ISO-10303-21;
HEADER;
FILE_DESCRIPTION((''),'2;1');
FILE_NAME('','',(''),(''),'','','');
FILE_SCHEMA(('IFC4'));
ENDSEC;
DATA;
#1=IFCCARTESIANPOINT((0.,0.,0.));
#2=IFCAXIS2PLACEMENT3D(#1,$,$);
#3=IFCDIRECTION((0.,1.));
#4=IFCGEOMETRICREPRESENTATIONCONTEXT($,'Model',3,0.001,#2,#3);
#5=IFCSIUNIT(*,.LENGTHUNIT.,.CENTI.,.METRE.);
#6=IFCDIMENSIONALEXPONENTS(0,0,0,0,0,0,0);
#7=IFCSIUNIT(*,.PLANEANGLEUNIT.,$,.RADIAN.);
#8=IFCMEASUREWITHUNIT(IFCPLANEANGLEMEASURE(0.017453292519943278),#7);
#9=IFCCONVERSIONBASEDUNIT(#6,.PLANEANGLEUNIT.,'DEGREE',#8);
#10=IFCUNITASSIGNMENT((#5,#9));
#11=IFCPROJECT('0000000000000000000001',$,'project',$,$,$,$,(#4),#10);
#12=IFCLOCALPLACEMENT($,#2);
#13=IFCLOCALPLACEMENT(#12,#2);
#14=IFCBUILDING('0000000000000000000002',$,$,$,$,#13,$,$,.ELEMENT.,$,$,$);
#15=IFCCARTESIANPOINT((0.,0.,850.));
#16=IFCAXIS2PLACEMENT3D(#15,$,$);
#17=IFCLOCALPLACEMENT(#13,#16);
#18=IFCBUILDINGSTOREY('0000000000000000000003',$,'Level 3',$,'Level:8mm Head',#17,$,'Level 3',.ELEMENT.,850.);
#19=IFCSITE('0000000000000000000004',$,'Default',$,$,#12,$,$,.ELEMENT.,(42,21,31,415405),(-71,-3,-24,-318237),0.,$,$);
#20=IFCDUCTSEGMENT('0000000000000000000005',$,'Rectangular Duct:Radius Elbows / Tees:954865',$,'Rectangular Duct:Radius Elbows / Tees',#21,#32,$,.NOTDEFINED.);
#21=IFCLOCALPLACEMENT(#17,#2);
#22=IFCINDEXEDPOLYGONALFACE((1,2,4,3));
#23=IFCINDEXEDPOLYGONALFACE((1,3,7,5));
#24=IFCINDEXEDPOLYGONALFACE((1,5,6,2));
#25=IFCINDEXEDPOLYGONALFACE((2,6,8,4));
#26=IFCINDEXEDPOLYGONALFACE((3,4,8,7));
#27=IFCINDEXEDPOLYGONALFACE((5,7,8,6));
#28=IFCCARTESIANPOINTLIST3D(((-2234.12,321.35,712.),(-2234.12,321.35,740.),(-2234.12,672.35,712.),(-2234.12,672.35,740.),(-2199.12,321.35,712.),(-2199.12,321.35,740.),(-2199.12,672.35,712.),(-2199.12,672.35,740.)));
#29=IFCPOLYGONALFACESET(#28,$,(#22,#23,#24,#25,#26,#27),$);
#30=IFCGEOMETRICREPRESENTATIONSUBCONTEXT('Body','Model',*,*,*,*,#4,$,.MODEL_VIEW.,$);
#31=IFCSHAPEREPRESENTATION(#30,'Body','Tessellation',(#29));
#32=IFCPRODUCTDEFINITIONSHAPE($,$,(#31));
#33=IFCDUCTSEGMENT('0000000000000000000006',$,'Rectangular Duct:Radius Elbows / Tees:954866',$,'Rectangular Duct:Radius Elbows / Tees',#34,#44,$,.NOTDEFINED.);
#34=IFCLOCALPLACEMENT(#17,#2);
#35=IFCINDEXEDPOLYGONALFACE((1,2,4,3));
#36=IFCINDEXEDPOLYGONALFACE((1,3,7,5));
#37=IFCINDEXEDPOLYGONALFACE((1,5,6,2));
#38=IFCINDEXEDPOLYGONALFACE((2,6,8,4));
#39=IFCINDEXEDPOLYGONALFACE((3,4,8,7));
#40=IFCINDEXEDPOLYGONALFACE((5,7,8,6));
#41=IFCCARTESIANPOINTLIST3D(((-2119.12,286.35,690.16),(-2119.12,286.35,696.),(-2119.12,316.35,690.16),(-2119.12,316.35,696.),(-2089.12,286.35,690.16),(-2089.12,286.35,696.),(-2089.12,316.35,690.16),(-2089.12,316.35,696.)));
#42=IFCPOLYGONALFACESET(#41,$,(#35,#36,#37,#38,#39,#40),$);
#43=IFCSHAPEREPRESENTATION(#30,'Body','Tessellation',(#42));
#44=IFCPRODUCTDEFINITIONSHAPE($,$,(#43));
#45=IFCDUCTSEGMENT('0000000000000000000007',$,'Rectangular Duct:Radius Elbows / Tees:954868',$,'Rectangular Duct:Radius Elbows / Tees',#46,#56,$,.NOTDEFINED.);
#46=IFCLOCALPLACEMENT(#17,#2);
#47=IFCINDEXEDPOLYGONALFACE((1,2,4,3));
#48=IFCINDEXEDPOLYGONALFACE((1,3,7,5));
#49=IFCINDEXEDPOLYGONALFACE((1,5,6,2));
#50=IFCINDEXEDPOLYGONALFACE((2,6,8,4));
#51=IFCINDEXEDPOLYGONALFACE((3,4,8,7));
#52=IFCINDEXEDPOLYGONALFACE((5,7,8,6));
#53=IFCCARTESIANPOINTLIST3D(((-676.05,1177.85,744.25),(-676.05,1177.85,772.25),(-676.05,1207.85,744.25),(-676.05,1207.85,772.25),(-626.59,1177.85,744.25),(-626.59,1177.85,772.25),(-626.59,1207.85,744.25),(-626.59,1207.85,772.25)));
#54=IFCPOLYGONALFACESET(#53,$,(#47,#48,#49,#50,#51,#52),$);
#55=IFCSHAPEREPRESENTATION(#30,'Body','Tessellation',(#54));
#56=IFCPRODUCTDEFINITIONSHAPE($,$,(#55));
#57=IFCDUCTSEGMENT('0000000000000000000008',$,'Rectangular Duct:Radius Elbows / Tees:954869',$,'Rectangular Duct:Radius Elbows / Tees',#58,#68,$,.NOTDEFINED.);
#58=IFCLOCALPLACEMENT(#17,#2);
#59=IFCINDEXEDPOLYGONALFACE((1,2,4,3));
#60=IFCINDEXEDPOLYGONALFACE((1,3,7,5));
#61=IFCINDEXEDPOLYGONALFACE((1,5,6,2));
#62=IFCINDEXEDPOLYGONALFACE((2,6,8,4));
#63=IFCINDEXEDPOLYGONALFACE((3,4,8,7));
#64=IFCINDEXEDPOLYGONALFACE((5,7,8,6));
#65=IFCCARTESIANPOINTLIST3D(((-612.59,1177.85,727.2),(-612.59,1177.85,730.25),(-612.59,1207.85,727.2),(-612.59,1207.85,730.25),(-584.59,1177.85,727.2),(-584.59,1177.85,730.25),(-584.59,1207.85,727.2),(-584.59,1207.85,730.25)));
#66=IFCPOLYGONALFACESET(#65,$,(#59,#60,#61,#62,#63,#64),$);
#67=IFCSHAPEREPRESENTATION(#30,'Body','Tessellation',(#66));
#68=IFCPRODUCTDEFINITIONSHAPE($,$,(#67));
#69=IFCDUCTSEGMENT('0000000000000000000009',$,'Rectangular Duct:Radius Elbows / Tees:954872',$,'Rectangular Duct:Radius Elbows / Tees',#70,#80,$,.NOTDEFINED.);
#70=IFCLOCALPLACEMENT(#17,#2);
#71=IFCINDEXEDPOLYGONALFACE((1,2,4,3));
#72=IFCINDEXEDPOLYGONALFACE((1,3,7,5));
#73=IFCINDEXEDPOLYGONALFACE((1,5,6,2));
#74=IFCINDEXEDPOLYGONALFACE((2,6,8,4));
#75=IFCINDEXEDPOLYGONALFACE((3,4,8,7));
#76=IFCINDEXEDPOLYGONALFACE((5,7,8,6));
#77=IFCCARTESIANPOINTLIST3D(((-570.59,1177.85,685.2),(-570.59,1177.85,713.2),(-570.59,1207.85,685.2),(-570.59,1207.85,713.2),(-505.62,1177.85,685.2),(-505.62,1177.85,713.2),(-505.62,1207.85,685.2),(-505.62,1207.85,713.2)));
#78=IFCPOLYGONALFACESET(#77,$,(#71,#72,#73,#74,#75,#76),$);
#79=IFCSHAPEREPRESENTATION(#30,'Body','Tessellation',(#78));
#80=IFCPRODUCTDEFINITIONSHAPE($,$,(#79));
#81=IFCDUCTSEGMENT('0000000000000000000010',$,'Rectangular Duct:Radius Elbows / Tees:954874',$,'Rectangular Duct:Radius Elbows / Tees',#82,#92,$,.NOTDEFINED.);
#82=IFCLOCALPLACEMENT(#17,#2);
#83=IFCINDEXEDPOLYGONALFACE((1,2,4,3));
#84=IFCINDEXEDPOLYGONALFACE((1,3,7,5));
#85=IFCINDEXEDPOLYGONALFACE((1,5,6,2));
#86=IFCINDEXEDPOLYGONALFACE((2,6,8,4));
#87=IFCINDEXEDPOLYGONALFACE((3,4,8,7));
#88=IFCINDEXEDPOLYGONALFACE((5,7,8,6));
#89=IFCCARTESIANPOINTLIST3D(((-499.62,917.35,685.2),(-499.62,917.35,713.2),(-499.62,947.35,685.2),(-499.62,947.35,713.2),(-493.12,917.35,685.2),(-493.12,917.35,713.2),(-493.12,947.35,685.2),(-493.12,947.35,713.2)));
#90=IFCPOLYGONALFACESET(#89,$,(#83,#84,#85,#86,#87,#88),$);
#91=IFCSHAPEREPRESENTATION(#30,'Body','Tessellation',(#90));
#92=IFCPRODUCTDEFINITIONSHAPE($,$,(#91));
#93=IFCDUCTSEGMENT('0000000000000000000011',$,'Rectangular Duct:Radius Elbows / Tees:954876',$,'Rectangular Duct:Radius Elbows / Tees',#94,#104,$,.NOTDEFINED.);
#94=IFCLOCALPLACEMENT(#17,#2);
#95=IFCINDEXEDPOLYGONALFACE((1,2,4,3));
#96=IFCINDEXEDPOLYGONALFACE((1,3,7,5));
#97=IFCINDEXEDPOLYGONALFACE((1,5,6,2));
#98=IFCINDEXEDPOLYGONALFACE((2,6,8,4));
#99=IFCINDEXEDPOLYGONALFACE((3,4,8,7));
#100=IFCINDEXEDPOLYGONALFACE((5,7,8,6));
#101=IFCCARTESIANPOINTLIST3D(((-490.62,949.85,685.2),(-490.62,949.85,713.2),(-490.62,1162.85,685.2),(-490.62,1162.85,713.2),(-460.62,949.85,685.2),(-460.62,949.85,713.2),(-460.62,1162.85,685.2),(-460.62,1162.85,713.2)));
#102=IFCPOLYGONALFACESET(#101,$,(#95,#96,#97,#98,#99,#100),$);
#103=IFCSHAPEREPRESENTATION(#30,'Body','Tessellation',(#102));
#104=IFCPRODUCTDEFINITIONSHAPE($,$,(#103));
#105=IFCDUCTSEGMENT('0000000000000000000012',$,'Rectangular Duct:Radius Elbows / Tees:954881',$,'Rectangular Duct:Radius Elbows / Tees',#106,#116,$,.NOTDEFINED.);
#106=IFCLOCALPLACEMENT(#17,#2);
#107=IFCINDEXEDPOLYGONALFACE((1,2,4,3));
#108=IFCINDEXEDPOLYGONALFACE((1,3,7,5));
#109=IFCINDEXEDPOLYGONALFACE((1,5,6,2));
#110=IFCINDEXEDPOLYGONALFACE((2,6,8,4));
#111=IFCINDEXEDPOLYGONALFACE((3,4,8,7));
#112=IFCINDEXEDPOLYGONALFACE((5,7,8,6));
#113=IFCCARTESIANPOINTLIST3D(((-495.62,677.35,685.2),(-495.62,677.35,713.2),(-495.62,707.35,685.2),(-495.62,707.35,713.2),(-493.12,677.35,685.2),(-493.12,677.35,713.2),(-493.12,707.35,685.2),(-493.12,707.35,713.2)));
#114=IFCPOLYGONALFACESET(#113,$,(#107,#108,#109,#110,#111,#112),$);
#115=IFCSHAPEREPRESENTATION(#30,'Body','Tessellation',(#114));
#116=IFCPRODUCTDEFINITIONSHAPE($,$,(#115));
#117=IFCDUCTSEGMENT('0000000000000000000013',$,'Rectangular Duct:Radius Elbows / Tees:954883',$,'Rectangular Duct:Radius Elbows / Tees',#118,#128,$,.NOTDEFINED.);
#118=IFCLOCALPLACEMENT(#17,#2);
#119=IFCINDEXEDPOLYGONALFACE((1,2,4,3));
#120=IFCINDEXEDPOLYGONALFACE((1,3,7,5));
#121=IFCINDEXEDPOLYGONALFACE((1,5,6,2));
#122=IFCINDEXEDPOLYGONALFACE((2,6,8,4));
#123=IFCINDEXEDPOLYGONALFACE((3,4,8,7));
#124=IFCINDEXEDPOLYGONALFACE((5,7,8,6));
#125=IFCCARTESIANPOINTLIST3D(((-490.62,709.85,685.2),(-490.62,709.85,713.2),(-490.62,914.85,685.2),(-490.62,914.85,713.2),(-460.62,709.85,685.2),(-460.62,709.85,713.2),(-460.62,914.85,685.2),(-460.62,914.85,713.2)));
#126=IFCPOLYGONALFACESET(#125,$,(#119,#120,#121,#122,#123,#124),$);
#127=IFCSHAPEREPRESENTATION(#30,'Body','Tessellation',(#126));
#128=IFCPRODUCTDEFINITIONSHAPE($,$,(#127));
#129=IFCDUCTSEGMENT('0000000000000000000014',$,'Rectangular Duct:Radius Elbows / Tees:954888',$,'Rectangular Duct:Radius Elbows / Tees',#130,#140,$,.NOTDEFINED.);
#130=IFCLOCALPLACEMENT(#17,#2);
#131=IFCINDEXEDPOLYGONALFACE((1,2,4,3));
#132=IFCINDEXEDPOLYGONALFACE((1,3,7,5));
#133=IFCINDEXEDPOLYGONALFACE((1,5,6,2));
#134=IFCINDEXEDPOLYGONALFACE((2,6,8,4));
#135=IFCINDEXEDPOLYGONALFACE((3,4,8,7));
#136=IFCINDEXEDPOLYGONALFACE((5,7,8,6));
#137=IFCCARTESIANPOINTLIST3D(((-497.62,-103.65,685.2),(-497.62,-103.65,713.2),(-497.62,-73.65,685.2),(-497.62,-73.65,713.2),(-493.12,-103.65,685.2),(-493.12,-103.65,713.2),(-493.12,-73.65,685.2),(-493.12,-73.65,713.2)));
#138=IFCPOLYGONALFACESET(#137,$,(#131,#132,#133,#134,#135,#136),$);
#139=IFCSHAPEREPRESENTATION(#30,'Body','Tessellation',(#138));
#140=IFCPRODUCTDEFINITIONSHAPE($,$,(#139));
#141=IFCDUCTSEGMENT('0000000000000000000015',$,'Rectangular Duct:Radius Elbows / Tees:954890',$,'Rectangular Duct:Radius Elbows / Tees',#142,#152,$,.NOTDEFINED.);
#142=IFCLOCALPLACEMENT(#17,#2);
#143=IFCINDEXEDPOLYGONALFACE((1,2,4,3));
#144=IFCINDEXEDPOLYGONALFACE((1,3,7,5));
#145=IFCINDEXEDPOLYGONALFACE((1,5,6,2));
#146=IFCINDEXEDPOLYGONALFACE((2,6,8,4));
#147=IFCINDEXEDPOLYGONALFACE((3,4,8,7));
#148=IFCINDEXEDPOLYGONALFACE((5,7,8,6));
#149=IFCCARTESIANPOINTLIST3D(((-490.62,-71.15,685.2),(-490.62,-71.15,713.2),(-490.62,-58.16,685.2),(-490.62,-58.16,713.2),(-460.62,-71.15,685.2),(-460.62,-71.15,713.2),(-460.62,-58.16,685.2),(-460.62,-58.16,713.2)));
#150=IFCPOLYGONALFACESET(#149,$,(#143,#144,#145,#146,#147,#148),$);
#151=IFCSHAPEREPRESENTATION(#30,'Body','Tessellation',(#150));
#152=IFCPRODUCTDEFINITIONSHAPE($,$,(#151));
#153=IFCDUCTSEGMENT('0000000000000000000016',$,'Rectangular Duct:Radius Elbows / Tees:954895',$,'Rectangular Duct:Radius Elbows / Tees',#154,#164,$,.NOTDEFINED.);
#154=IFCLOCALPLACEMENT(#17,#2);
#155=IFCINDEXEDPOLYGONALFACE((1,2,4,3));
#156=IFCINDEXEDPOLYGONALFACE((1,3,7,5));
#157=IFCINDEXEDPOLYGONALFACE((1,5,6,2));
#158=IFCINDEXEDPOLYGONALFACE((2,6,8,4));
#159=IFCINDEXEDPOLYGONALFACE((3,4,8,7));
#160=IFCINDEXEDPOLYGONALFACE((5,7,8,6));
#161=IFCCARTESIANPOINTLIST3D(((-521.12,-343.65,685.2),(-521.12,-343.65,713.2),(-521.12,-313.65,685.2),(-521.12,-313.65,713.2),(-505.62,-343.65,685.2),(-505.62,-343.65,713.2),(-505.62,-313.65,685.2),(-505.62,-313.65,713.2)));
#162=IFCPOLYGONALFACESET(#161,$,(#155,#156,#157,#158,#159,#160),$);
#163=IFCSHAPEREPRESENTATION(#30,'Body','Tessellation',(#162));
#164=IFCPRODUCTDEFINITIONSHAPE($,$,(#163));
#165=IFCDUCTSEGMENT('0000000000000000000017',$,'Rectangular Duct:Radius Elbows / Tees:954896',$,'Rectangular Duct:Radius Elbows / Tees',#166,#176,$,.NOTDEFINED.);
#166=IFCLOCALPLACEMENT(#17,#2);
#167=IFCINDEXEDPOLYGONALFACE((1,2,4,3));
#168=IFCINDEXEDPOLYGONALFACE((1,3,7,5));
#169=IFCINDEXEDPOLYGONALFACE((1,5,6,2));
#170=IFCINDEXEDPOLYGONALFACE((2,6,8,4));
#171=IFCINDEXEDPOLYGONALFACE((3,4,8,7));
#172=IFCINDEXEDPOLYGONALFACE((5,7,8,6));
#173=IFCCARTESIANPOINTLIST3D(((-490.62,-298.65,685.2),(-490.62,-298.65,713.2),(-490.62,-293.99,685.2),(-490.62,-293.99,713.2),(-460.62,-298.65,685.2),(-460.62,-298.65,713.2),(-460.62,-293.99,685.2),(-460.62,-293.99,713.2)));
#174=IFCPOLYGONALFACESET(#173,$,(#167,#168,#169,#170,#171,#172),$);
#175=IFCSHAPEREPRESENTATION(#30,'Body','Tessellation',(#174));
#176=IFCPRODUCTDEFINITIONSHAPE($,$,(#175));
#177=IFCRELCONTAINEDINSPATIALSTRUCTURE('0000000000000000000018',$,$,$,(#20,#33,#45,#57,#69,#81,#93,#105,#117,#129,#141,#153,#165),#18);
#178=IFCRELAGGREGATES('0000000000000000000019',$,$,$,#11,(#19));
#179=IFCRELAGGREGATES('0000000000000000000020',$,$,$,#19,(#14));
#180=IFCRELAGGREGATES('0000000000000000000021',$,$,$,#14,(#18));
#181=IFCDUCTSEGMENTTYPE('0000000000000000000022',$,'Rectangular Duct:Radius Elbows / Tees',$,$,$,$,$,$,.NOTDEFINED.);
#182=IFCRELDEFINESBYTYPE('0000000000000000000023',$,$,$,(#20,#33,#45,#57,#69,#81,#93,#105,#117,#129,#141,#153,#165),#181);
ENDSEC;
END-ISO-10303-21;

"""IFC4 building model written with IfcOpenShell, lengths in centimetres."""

from ifc_helpers import new_model, entity, si_unit, converted_unit, direction, frame, origin, place, context, subcontext, project, spatial, indexed_curve, outline, extrude, type_object, element, save


model = new_model("IFC4")

# Units and contexts
model_context = context("Model", 3, precision=0.001, world=origin(), true_north=direction((0.0, 1.0)))
body_context = subcontext(model_context, "Body", "Model", "MODEL_VIEW")
ifc_project = project(units=[si_unit("LENGTHUNIT", "METRE", prefix="CENTI"), converted_unit("PLANEANGLEUNIT", "DEGREE", entity("IfcPlaneAngleMeasure", 0.017453292519943278), si_unit("PLANEANGLEUNIT", "RADIAN"), dimensions=[0, 0, 0, 0, 0, 0, 0])], contexts=[model_context])

# Site, building, storey
site_placement = place(None, origin())
site = spatial("IfcSite", under=ifc_project, at=site_placement, Name="Default", CompositionType="ELEMENT", RefLatitude=(42, 21, 31, 415405), RefLongitude=(-71, -3, -24, -318237), RefElevation=0.0)
building_placement = place(site_placement, origin())
building = spatial("IfcBuilding", under=site, at=building_placement, CompositionType="ELEMENT")
storey_placement = place(building_placement, frame((0.0, 0.0, 850.0)))
storey = spatial("IfcBuildingStorey", under=building, at=storey_placement, Name="Level 3", ObjectType="Level:8mm Head", LongName="Level 3", CompositionType="ELEMENT", Elevation=850.0)

# Duct segments
duct_segment_type = type_object("IfcDuctSegmentType", Name="Rectangular Duct:Radius Elbows / Tees", PredefinedType="NOTDEFINED")
duct_segment_1_placement = place(storey_placement, origin())
element("IfcDuctSegment", 1, at=duct_segment_1_placement, inside=storey, type_object=duct_segment_type, Name="Rectangular Duct:Radius Elbows / Tees:954865", ObjectType="Rectangular Duct:Radius Elbows / Tees", PredefinedType="NOTDEFINED", context=body_context, shape_type="SweptSolid", body=[
    extrude(outline(indexed_curve([(-175.5, -17.5), (175.5, -17.5), (175.5, 17.5), (-175.5, 17.5), (-175.5, -17.5)], self_intersect=False)), frame((-2216.62, 496.85, 712.0), z_axis=(0.0, 0.0, 1.0), x_axis=(0.0, -1.0, 0.0)), (0.0, 0.0, 1.0), 28.0),
])
duct_segment_2_placement = place(storey_placement, origin())
element("IfcDuctSegment", 2, at=duct_segment_2_placement, inside=storey, type_object=duct_segment_type, Name="Rectangular Duct:Radius Elbows / Tees:954866", ObjectType="Rectangular Duct:Radius Elbows / Tees", PredefinedType="NOTDEFINED", context=body_context, shape_type="SweptSolid", body=[
    extrude(outline(indexed_curve([(-15.0, -15.0), (15.0, -15.0), (15.0, 15.0), (-15.0, 15.0), (-15.0, -15.0)], self_intersect=False)), frame((-2104.12, 301.35, 690.16)), (0.0, 0.0, 1.0), 5.84),
])
duct_segment_3_placement = place(storey_placement, origin())
element("IfcDuctSegment", 3, at=duct_segment_3_placement, inside=storey, type_object=duct_segment_type, Name="Rectangular Duct:Radius Elbows / Tees:954868", ObjectType="Rectangular Duct:Radius Elbows / Tees", PredefinedType="NOTDEFINED", context=body_context, shape_type="SweptSolid", body=[
    extrude(outline(indexed_curve([(-24.73, -15.0), (24.73, -15.0), (24.73, 15.0), (-24.73, 15.0), (-24.73, -15.0)], self_intersect=False)), frame((-651.32, 1192.85, 744.25)), (0.0, 0.0, 1.0), 28.0),
])
duct_segment_4_placement = place(storey_placement, origin())
element("IfcDuctSegment", 4, at=duct_segment_4_placement, inside=storey, type_object=duct_segment_type, Name="Rectangular Duct:Radius Elbows / Tees:954869", ObjectType="Rectangular Duct:Radius Elbows / Tees", PredefinedType="NOTDEFINED", context=body_context, shape_type="SweptSolid", body=[
    extrude(outline(indexed_curve([(-15.0, -14.0), (15.0, -14.0), (15.0, 14.0), (-15.0, 14.0), (-15.0, -14.0)], self_intersect=False)), frame((-598.59, 1192.85, 727.2), z_axis=(0.0, 0.0, 1.0), x_axis=(0.0, -1.0, 0.0)), (0.0, 0.0, 1.0), 3.05),
])
duct_segment_5_placement = place(storey_placement, origin())
element("IfcDuctSegment", 5, at=duct_segment_5_placement, inside=storey, type_object=duct_segment_type, Name="Rectangular Duct:Radius Elbows / Tees:954872", ObjectType="Rectangular Duct:Radius Elbows / Tees", PredefinedType="NOTDEFINED", context=body_context, shape_type="SweptSolid", body=[
    extrude(outline(indexed_curve([(-32.48, -15.0), (32.48, -15.0), (32.48, 15.0), (-32.48, 15.0), (-32.48, -15.0)], self_intersect=False)), frame((-538.11, 1192.85, 685.2)), (0.0, 0.0, 1.0), 28.0),
])
duct_segment_6_placement = place(storey_placement, origin())
element("IfcDuctSegment", 6, at=duct_segment_6_placement, inside=storey, type_object=duct_segment_type, Name="Rectangular Duct:Radius Elbows / Tees:954874", ObjectType="Rectangular Duct:Radius Elbows / Tees", PredefinedType="NOTDEFINED", context=body_context, shape_type="SweptSolid", body=[
    extrude(outline(indexed_curve([(-3.25, -15.0), (3.25, -15.0), (3.25, 15.0), (-3.25, 15.0), (-3.25, -15.0)], self_intersect=False)), frame((-496.37, 932.35, 685.2), z_axis=(0.0, 0.0, 1.0), x_axis=(-1.0, 0.0, 0.0)), (0.0, 0.0, 1.0), 28.0),
])
duct_segment_7_placement = place(storey_placement, origin())
element("IfcDuctSegment", 7, at=duct_segment_7_placement, inside=storey, type_object=duct_segment_type, Name="Rectangular Duct:Radius Elbows / Tees:954876", ObjectType="Rectangular Duct:Radius Elbows / Tees", PredefinedType="NOTDEFINED", context=body_context, shape_type="SweptSolid", body=[
    extrude(outline(indexed_curve([(-106.5, -15.0), (106.5, -15.0), (106.5, 15.0), (-106.5, 15.0), (-106.5, -15.0)], self_intersect=False)), frame((-475.62, 1056.35, 685.2), z_axis=(0.0, 0.0, 1.0), x_axis=(0.0, -1.0, 0.0)), (0.0, 0.0, 1.0), 28.0),
])
duct_segment_8_placement = place(storey_placement, origin())
element("IfcDuctSegment", 8, at=duct_segment_8_placement, inside=storey, type_object=duct_segment_type, Name="Rectangular Duct:Radius Elbows / Tees:954881", ObjectType="Rectangular Duct:Radius Elbows / Tees", PredefinedType="NOTDEFINED", context=body_context, shape_type="SweptSolid", body=[
    extrude(outline(indexed_curve([(-1.25, -15.0), (1.25, -15.0), (1.25, 15.0), (-1.25, 15.0), (-1.25, -15.0)], self_intersect=False)), frame((-494.37, 692.35, 685.2), z_axis=(0.0, 0.0, 1.0), x_axis=(-1.0, 0.0, 0.0)), (0.0, 0.0, 1.0), 28.0),
])
duct_segment_9_placement = place(storey_placement, origin())
element("IfcDuctSegment", 9, at=duct_segment_9_placement, inside=storey, type_object=duct_segment_type, Name="Rectangular Duct:Radius Elbows / Tees:954883", ObjectType="Rectangular Duct:Radius Elbows / Tees", PredefinedType="NOTDEFINED", context=body_context, shape_type="SweptSolid", body=[
    extrude(outline(indexed_curve([(-102.5, -15.0), (102.5, -15.0), (102.5, 15.0), (-102.5, 15.0), (-102.5, -15.0)], self_intersect=False)), frame((-475.62, 812.35, 685.2), z_axis=(0.0, 0.0, 1.0), x_axis=(0.0, -1.0, 0.0)), (0.0, 0.0, 1.0), 28.0),
])
duct_segment_10_placement = place(storey_placement, origin())
element("IfcDuctSegment", 10, at=duct_segment_10_placement, inside=storey, type_object=duct_segment_type, Name="Rectangular Duct:Radius Elbows / Tees:954888", ObjectType="Rectangular Duct:Radius Elbows / Tees", PredefinedType="NOTDEFINED", context=body_context, shape_type="SweptSolid", body=[
    extrude(outline(indexed_curve([(-2.25, -15.0), (2.25, -15.0), (2.25, 15.0), (-2.25, 15.0), (-2.25, -15.0)], self_intersect=False)), frame((-495.37, -88.65, 685.2), z_axis=(0.0, 0.0, 1.0), x_axis=(-1.0, 0.0, 0.0)), (0.0, 0.0, 1.0), 28.0),
])
duct_segment_11_placement = place(storey_placement, origin())
element("IfcDuctSegment", 11, at=duct_segment_11_placement, inside=storey, type_object=duct_segment_type, Name="Rectangular Duct:Radius Elbows / Tees:954890", ObjectType="Rectangular Duct:Radius Elbows / Tees", PredefinedType="NOTDEFINED", context=body_context, shape_type="SweptSolid", body=[
    extrude(outline(indexed_curve([(-6.5, -15.0), (6.5, -15.0), (6.5, 15.0), (-6.5, 15.0), (-6.5, -15.0)], self_intersect=False)), frame((-475.62, -64.66, 685.2), z_axis=(0.0, 0.0, 1.0), x_axis=(0.0, -1.0, 0.0)), (0.0, 0.0, 1.0), 28.0),
])
duct_segment_12_placement = place(storey_placement, origin())
element("IfcDuctSegment", 12, at=duct_segment_12_placement, inside=storey, type_object=duct_segment_type, Name="Rectangular Duct:Radius Elbows / Tees:954895", ObjectType="Rectangular Duct:Radius Elbows / Tees", PredefinedType="NOTDEFINED", context=body_context, shape_type="SweptSolid", body=[
    extrude(outline(indexed_curve([(-7.75, -15.0), (7.75, -15.0), (7.75, 15.0), (-7.75, 15.0), (-7.75, -15.0)], self_intersect=False)), frame((-513.37, -328.65, 685.2), z_axis=(0.0, 0.0, 1.0), x_axis=(-1.0, 0.0, 0.0)), (0.0, 0.0, 1.0), 28.0),
])
duct_segment_13_placement = place(storey_placement, origin())
element("IfcDuctSegment", 13, at=duct_segment_13_placement, inside=storey, type_object=duct_segment_type, Name="Rectangular Duct:Radius Elbows / Tees:954896", ObjectType="Rectangular Duct:Radius Elbows / Tees", PredefinedType="NOTDEFINED", context=body_context, shape_type="SweptSolid", body=[
    extrude(outline(indexed_curve([(-2.33, -15.0), (2.33, -15.0), (2.33, 15.0), (-2.33, 15.0), (-2.33, -15.0)], self_intersect=False)), frame((-475.62, -296.32, 685.2), z_axis=(0.0, 0.0, 1.0), x_axis=(0.0, -1.0, 0.0)), (0.0, 0.0, 1.0), 28.0),
])

save(model, "model.ifc")
